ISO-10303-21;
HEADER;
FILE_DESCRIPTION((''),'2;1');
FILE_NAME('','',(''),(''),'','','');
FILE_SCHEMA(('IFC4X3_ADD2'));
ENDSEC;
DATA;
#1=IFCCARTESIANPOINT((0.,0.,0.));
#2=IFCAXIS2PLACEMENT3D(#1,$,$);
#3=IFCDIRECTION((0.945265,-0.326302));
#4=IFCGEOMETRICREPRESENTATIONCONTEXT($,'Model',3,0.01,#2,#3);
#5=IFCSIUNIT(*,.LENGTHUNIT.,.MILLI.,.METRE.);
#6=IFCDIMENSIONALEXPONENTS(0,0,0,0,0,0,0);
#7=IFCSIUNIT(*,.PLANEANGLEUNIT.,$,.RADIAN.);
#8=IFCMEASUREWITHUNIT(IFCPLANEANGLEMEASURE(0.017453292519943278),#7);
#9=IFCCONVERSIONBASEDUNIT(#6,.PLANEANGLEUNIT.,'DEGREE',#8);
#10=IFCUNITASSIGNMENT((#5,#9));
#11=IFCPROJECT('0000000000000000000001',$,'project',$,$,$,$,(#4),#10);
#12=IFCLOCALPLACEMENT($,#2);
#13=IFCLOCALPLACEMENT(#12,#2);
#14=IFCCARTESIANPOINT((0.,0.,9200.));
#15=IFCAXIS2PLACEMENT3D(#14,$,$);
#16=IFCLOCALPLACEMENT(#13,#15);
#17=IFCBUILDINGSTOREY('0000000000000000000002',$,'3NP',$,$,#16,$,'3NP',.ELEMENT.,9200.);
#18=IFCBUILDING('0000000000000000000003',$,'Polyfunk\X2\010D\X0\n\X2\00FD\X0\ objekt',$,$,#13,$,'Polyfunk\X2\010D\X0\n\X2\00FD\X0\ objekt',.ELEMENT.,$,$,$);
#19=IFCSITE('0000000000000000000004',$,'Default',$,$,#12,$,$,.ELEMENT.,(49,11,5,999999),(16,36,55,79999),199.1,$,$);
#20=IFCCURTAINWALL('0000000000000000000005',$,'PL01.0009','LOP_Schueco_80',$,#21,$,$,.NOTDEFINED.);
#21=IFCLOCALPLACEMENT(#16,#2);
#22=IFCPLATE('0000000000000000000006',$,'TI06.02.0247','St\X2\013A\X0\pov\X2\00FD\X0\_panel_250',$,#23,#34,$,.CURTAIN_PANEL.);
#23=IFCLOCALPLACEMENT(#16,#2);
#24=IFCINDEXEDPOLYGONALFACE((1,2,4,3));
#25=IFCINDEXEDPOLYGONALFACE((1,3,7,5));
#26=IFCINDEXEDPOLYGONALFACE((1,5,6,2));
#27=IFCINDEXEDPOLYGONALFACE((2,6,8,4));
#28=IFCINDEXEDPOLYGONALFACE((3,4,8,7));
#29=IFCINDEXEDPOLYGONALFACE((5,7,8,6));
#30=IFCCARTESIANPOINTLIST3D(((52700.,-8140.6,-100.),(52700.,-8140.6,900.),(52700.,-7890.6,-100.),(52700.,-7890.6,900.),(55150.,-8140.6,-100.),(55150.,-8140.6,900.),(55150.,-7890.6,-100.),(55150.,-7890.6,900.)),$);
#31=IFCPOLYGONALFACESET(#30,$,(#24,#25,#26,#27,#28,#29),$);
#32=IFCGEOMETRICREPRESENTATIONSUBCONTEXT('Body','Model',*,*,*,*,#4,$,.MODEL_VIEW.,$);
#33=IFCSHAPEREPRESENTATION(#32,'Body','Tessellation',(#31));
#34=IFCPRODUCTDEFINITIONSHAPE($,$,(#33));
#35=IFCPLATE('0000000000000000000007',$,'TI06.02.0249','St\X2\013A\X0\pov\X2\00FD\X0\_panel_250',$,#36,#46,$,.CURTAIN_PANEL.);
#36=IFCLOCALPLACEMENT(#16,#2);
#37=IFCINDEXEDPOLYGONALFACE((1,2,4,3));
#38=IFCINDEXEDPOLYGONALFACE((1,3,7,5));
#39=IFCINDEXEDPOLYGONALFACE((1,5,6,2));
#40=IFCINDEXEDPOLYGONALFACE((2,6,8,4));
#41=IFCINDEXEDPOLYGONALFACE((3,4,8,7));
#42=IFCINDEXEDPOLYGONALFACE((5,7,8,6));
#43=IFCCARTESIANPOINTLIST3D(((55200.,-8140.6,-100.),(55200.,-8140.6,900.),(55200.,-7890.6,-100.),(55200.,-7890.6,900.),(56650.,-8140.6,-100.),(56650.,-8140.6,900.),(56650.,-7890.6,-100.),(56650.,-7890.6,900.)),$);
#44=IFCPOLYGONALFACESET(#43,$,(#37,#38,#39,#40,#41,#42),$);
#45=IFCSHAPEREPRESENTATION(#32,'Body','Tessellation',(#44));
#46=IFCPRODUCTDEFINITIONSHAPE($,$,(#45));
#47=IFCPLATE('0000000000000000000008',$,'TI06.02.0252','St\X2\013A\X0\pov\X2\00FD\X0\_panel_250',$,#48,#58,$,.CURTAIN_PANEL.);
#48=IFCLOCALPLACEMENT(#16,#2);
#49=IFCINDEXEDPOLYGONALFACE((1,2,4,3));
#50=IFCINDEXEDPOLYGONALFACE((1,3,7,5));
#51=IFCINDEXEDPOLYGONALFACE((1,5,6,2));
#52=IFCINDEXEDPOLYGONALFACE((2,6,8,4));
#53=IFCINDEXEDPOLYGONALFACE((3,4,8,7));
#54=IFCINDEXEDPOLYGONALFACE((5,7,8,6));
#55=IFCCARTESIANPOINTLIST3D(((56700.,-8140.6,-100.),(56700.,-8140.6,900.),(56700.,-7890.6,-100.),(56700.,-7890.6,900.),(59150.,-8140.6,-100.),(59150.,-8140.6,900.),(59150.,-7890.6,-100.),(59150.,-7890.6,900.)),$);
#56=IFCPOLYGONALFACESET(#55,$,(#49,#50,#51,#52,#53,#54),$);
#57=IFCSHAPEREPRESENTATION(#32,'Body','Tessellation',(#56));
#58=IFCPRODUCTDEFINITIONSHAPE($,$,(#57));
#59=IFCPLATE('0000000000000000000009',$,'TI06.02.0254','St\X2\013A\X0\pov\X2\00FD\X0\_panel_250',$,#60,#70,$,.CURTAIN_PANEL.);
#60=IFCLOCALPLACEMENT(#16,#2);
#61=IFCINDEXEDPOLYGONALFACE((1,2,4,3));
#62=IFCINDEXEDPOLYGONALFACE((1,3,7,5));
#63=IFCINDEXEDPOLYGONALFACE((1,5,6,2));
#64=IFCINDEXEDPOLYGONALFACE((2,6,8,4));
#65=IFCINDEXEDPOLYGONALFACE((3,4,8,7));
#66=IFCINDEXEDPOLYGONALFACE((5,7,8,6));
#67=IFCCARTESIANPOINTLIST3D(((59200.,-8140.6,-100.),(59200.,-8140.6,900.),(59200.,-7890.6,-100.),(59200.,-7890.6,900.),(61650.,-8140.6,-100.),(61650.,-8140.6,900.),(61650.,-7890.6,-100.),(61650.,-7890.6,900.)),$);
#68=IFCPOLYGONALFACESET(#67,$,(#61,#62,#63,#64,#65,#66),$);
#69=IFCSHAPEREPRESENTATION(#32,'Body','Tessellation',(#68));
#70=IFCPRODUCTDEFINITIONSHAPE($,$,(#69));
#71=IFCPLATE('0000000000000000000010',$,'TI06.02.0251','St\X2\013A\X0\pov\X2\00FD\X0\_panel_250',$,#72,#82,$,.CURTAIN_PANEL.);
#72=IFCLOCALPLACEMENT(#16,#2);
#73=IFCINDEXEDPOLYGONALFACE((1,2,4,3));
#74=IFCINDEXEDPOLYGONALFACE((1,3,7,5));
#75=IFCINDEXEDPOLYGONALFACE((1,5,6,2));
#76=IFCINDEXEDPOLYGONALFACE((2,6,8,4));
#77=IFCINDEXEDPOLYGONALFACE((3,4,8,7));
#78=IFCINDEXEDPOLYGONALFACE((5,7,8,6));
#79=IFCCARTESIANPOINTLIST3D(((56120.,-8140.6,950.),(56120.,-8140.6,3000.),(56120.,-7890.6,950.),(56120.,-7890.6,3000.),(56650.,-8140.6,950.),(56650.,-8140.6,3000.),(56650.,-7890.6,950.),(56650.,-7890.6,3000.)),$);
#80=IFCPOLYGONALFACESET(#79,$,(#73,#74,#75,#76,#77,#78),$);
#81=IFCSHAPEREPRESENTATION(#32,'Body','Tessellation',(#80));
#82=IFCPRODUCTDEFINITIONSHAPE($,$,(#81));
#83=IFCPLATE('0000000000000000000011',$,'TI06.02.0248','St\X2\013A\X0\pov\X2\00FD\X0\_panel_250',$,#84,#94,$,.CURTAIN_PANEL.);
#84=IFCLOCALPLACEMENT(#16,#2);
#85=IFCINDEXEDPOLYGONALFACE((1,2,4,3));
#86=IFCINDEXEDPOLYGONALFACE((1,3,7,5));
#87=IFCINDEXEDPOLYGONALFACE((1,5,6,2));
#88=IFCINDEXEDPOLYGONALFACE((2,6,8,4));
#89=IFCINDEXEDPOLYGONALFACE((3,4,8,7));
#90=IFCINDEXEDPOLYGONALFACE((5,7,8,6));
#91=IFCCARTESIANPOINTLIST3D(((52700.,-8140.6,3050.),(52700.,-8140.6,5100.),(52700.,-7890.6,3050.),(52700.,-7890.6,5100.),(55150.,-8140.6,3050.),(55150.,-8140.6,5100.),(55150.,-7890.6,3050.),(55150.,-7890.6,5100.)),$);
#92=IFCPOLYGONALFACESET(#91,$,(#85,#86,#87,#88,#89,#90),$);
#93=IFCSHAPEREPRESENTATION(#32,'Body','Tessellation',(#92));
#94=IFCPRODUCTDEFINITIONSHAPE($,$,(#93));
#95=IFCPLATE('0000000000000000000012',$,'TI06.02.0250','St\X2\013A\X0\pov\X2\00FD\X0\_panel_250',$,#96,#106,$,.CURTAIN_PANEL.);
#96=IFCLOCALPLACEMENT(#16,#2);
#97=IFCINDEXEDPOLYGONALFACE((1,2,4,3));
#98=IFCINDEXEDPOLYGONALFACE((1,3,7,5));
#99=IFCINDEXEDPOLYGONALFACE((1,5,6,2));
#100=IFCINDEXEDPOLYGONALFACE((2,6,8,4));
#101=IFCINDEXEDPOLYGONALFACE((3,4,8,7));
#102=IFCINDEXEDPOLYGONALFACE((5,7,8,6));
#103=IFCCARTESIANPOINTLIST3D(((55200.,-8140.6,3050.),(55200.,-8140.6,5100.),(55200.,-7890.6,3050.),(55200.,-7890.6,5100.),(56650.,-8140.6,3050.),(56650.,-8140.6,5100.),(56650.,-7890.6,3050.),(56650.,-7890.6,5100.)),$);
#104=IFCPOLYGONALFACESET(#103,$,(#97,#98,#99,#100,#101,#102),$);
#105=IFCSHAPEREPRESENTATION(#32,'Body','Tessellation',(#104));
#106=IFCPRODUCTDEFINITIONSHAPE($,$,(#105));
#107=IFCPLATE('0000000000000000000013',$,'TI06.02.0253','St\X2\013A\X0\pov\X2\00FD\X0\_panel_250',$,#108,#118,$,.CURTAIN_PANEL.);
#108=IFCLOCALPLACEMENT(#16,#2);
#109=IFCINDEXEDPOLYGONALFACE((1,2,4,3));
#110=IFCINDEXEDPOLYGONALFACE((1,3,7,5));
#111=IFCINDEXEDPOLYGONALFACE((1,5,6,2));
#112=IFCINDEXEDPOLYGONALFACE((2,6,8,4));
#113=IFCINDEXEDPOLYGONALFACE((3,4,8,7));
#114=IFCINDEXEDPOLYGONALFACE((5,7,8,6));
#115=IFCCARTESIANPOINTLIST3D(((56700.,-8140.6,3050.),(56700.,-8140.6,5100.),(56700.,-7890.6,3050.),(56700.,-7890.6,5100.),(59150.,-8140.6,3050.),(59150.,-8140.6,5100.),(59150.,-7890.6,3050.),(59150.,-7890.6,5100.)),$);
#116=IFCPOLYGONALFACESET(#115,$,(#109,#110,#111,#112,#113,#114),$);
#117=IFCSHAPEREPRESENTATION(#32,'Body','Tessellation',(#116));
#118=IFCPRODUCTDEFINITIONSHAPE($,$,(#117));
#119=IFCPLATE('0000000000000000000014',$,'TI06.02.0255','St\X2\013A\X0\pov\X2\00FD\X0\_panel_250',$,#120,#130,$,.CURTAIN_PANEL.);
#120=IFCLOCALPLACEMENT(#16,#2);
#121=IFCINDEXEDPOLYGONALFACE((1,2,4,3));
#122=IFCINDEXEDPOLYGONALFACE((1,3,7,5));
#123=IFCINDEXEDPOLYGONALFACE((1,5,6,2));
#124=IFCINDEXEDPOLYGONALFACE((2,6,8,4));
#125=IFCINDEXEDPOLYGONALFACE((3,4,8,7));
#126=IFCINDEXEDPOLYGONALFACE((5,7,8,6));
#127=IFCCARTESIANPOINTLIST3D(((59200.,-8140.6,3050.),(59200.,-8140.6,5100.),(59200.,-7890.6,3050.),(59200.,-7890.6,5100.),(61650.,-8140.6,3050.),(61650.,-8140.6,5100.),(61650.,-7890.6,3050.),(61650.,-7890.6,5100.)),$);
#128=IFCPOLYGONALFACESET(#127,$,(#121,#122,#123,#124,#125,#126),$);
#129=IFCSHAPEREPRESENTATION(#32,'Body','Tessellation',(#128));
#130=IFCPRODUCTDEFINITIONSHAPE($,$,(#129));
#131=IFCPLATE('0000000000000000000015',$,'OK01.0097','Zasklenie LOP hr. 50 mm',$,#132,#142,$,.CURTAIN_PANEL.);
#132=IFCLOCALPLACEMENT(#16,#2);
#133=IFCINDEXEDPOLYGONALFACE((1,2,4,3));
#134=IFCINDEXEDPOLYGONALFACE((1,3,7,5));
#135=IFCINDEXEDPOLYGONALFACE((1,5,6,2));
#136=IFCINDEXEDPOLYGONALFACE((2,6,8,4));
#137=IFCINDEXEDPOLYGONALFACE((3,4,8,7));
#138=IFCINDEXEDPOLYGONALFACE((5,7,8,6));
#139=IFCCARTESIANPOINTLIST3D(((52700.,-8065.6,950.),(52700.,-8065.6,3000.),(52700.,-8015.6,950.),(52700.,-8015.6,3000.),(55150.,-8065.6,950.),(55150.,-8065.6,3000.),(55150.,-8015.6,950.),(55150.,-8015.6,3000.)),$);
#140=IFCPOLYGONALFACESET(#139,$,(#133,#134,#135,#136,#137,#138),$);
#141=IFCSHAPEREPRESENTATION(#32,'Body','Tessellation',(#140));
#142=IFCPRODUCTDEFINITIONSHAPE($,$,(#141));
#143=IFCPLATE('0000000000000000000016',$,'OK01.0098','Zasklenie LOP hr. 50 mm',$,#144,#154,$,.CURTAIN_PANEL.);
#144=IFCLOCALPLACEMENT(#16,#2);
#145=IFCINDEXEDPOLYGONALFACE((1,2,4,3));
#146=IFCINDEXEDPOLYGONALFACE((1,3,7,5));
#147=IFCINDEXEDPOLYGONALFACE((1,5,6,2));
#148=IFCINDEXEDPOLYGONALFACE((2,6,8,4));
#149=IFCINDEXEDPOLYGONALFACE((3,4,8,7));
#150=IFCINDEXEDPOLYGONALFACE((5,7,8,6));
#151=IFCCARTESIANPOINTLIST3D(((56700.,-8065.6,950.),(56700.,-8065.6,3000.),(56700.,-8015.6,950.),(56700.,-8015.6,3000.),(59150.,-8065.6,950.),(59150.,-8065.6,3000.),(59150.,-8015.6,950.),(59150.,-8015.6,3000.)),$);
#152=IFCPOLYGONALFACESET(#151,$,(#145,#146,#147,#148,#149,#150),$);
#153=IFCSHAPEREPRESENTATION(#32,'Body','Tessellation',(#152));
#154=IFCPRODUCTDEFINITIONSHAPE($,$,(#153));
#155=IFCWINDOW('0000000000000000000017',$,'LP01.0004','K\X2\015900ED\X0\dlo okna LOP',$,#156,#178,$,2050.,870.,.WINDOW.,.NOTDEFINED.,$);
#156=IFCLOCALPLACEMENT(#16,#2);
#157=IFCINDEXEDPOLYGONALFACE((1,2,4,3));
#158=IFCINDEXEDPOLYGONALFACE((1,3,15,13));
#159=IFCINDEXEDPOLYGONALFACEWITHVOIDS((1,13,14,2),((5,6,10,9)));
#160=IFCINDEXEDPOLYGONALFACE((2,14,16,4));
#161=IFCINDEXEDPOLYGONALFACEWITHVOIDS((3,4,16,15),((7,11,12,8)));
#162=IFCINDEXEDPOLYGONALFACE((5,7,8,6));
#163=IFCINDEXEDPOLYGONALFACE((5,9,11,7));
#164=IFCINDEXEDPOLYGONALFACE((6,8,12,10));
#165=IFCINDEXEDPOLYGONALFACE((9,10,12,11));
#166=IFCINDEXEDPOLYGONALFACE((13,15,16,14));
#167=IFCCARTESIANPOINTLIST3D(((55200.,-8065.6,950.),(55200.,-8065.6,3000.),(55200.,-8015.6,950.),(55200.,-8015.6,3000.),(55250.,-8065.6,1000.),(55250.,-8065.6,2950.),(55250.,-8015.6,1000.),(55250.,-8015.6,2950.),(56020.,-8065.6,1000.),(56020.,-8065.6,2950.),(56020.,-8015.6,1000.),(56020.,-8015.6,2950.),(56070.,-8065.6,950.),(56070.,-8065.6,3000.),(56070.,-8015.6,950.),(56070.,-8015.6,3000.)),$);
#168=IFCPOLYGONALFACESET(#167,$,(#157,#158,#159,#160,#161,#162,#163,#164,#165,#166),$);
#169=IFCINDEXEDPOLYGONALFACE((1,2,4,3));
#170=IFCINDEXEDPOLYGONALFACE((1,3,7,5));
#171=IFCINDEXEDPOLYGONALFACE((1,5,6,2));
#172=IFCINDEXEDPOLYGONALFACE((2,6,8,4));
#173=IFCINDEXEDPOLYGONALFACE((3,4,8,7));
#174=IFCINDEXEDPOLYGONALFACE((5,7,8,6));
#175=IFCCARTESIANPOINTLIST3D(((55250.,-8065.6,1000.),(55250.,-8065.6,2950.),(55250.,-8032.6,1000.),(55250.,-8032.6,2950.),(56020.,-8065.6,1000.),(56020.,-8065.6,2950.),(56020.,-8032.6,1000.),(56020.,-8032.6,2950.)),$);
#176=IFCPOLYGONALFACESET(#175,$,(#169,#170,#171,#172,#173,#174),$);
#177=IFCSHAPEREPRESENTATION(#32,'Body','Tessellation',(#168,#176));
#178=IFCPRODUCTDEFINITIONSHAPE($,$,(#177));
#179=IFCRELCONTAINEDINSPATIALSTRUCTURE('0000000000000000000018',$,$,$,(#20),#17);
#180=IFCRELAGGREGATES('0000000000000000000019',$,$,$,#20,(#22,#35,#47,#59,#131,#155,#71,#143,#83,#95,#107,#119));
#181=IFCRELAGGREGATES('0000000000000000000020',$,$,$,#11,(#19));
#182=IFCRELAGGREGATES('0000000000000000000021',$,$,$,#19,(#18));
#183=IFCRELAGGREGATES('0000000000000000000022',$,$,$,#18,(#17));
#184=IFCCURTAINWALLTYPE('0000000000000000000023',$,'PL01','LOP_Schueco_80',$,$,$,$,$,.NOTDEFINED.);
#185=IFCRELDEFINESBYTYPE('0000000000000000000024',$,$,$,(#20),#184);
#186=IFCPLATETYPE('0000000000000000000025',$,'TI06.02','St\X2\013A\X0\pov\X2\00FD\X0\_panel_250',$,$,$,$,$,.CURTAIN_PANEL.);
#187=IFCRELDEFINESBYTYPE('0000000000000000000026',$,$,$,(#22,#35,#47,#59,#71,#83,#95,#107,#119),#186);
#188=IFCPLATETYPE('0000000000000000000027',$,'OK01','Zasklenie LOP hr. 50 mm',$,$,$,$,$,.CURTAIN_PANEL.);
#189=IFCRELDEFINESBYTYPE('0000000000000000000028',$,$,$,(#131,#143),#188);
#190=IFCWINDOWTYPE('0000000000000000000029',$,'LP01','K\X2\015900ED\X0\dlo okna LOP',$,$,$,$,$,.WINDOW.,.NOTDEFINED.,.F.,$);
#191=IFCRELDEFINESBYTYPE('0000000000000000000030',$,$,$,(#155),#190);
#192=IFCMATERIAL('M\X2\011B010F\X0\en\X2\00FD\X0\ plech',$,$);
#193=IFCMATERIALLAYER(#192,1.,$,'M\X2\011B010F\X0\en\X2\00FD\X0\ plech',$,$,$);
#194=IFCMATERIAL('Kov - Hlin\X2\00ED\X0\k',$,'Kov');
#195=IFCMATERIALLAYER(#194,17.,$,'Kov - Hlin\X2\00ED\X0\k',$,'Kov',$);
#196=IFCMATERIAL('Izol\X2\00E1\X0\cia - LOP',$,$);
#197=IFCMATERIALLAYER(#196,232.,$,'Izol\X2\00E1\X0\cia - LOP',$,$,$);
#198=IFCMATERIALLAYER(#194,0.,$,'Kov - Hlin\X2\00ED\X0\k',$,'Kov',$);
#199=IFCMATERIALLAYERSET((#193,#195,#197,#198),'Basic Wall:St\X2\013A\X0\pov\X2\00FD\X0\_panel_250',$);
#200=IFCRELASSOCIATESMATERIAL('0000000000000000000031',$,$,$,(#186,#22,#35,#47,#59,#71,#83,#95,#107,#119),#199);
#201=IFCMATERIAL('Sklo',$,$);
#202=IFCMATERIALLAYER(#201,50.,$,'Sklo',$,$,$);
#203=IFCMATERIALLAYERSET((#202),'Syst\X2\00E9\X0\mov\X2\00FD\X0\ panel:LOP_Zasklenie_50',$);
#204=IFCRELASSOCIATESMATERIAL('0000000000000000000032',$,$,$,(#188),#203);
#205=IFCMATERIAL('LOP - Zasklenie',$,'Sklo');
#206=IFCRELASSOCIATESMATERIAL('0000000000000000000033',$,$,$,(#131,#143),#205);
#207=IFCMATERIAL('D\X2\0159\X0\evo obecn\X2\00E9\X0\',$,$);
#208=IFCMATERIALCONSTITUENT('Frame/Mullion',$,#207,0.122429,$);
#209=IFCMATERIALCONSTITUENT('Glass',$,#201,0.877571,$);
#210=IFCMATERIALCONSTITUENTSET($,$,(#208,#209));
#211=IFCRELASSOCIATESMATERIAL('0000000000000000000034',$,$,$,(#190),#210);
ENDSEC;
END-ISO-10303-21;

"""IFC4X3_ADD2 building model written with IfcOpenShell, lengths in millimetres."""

from ifc_helpers import new_model, entity, si_unit, converted_unit, direction, frame, frame_2d, origin, origin_2d_with_axis, place, context, subcontext, project, spatial, polyline, rectangle, outline, extrude, source, transform, mapped, material, layer, layer_set, layer_usage, constituent, constituent_set, type_object, type_shapes, element, aggregate, save


model = new_model("IFC4X3_ADD2")

# Units and contexts
model_context = context("Model", 3, precision=0.01, world=origin(), true_north=direction((0.945265, -0.326302)))
body_context = subcontext(model_context, "Body", "Model", "MODEL_VIEW")
ifc_project = project(units=[si_unit("LENGTHUNIT", "METRE", prefix="MILLI"), converted_unit("PLANEANGLEUNIT", "DEGREE", entity("IfcPlaneAngleMeasure", 0.017453292519943278), si_unit("PLANEANGLEUNIT", "RADIAN"), dimensions=[0, 0, 0, 0, 0, 0, 0])], contexts=[model_context])

# Site, building, storey
site_placement = place(None, origin())
site = spatial("IfcSite", under=ifc_project, at=site_placement, Name="Default", CompositionType="ELEMENT", RefLatitude=(49, 11, 5, 999999), RefLongitude=(16, 36, 55, 79999), RefElevation=199.1)
building_placement = place(site_placement, origin())
building = spatial("IfcBuilding", under=site, at=building_placement, Name="Polyfunkčný objekt", LongName="Polyfunkčný objekt", CompositionType="ELEMENT")
storey_placement = place(building_placement, frame((0.0, 0.0, 9200.0)))
storey = spatial("IfcBuildingStorey", under=building, at=storey_placement, Name="3NP", LongName="3NP", CompositionType="ELEMENT", Elevation=9200.0)

# Curtain wall, plates, window
curtain_wall_type = type_object("IfcCurtainWallType", Name="PL01", Description="LOP_Schueco_80", PredefinedType="NOTDEFINED")
curtain_wall_placement = place(storey_placement, frame((0.0, 0.0, -9200.0)))
curtain_wall = element("IfcCurtainWall", 1, at=curtain_wall_placement, inside=storey, type_object=curtain_wall_type, Name="PL01.0009", Description="LOP_Schueco_80", PredefinedType="NOTDEFINED")
ifc_material_1 = material(Name="Měďený plech")
ifc_layer_1 = layer(ifc_material_1, 1.0, Name="Měďený plech")
ifc_material_2 = material(Name="Kov - Hliník", Category="Kov")
ifc_layer_2 = layer(ifc_material_2, 17.0, Name="Kov - Hliník", Category="Kov")
ifc_material_3 = material(Name="Izolácia - LOP")
ifc_layer_3 = layer(ifc_material_3, 232.0, Name="Izolácia - LOP")
ifc_layer_4 = layer(ifc_material_2, 0.0, Name="Kov - Hliník", Category="Kov")
ifc_layer_set_1 = layer_set([ifc_layer_1, ifc_layer_2, ifc_layer_3, ifc_layer_4], Name="Basic Wall:Stĺpový_panel_250")
ifc_layer_usage_1 = layer_usage(ifc_layer_set_1, "AXIS2", "POSITIVE", -125.0)
plate_type_1 = type_object("IfcPlateType", Name="TI06.02", Description="Stĺpový_panel_250", PredefinedType="CURTAIN_PANEL", material=ifc_layer_set_1)
plate_1_placement = place(storey_placement, frame((52700.0, -8015.6, -100.0)))
plate_1 = element("IfcPlate", 2, at=plate_1_placement, type_object=plate_type_1, material=ifc_layer_usage_1, Name="TI06.02.0247", Description="Stĺpový_panel_250", PredefinedType="CURTAIN_PANEL", context=body_context, shape_type="SweptSolid", body=[
    extrude(rectangle(XDim=250.0, YDim=2450.0, at=frame_2d((0.0, 0.0), x_axis=(1.0, 0.0))), frame((1225.0, 0.0, 0.0), z_axis=(0.0, 0.0, 1.0), x_axis=(0.0, 1.0, 0.0)), (0.0, 0.0, 1.0), 1000.0),
])
ifc_layer_usage_2 = layer_usage(ifc_layer_set_1, "AXIS2", "POSITIVE", -125.0)
plate_2_placement = place(storey_placement, frame((55200.0, -8015.6, -100.0)))
plate_2 = element("IfcPlate", 3, at=plate_2_placement, type_object=plate_type_1, material=ifc_layer_usage_2, Name="TI06.02.0249", Description="Stĺpový_panel_250", PredefinedType="CURTAIN_PANEL", context=body_context, shape_type="SweptSolid", body=[
    extrude(rectangle(XDim=250.0, YDim=1450.0, at=frame_2d((0.0, 0.0), x_axis=(1.0, 0.0))), frame((725.0, 0.0, 0.0), z_axis=(0.0, 0.0, 1.0), x_axis=(0.0, 1.0, 0.0)), (0.0, 0.0, 1.0), 1000.0),
])
ifc_layer_usage_3 = layer_usage(ifc_layer_set_1, "AXIS2", "POSITIVE", -125.0)
plate_3_placement = place(storey_placement, frame((56700.0, -8015.6, -100.0)))
plate_3 = element("IfcPlate", 4, at=plate_3_placement, type_object=plate_type_1, material=ifc_layer_usage_3, Name="TI06.02.0252", Description="Stĺpový_panel_250", PredefinedType="CURTAIN_PANEL", context=body_context, shape_type="SweptSolid", body=[
    extrude(rectangle(XDim=250.0, YDim=2450.0, at=frame_2d((0.0, 0.0), x_axis=(1.0, 0.0))), frame((1225.0, 0.0, 0.0), z_axis=(0.0, 0.0, 1.0), x_axis=(0.0, 1.0, 0.0)), (0.0, 0.0, 1.0), 1000.0),
])
ifc_layer_usage_4 = layer_usage(ifc_layer_set_1, "AXIS2", "POSITIVE", -125.0)
plate_4_placement = place(storey_placement, frame((59200.0, -8015.6, -100.0)))
plate_4 = element("IfcPlate", 5, at=plate_4_placement, type_object=plate_type_1, material=ifc_layer_usage_4, Name="TI06.02.0254", Description="Stĺpový_panel_250", PredefinedType="CURTAIN_PANEL", context=body_context, shape_type="SweptSolid", body=[
    extrude(rectangle(XDim=250.0, YDim=2450.0, at=frame_2d((0.0, 0.0), x_axis=(1.0, 0.0))), frame((1225.0, 0.0, 0.0), z_axis=(0.0, 0.0, 1.0), x_axis=(0.0, 1.0, 0.0)), (0.0, 0.0, 1.0), 1000.0),
])
ifc_layer_usage_5 = layer_usage(ifc_layer_set_1, "AXIS2", "POSITIVE", -125.0)
plate_5_placement = place(storey_placement, frame((56120.0, -8015.6, 950.0)))
plate_5 = element("IfcPlate", 6, at=plate_5_placement, type_object=plate_type_1, material=ifc_layer_usage_5, Name="TI06.02.0251", Description="Stĺpový_panel_250", PredefinedType="CURTAIN_PANEL", context=body_context, shape_type="SweptSolid", body=[
    extrude(rectangle(XDim=250.0, YDim=530.0, at=origin_2d_with_axis()), frame((265.0, 0.0, 0.0), z_axis=(0.0, 0.0, 1.0), x_axis=(0.0, 1.0, 0.0)), (0.0, 0.0, 1.0), 2050.0),
])
ifc_layer_usage_6 = layer_usage(ifc_layer_set_1, "AXIS2", "POSITIVE", -125.0)
plate_6_placement = place(storey_placement, frame((52700.0, -8015.6, 3050.0)))
plate_6 = element("IfcPlate", 7, at=plate_6_placement, type_object=plate_type_1, material=ifc_layer_usage_6, Name="TI06.02.0248", Description="Stĺpový_panel_250", PredefinedType="CURTAIN_PANEL", context=body_context, shape_type="SweptSolid", body=[
    extrude(rectangle(XDim=250.0, YDim=2450.0, at=frame_2d((0.0, 0.0), x_axis=(1.0, 0.0))), frame((1225.0, 0.0, 0.0), z_axis=(0.0, 0.0, 1.0), x_axis=(0.0, 1.0, 0.0)), (0.0, 0.0, 1.0), 2050.0),
])
ifc_layer_usage_7 = layer_usage(ifc_layer_set_1, "AXIS2", "POSITIVE", -125.0)
plate_7_placement = place(storey_placement, frame((55200.0, -8015.6, 3050.0)))
plate_7 = element("IfcPlate", 8, at=plate_7_placement, type_object=plate_type_1, material=ifc_layer_usage_7, Name="TI06.02.0250", Description="Stĺpový_panel_250", PredefinedType="CURTAIN_PANEL", context=body_context, shape_type="SweptSolid", body=[
    extrude(rectangle(XDim=250.0, YDim=1450.0, at=frame_2d((0.0, 0.0), x_axis=(1.0, 0.0))), frame((725.0, 0.0, 0.0), z_axis=(0.0, 0.0, 1.0), x_axis=(0.0, 1.0, 0.0)), (0.0, 0.0, 1.0), 2050.0),
])
ifc_layer_usage_8 = layer_usage(ifc_layer_set_1, "AXIS2", "POSITIVE", -125.0)
plate_8_placement = place(storey_placement, frame((56700.0, -8015.6, 3050.0)))
plate_8 = element("IfcPlate", 9, at=plate_8_placement, type_object=plate_type_1, material=ifc_layer_usage_8, Name="TI06.02.0253", Description="Stĺpový_panel_250", PredefinedType="CURTAIN_PANEL", context=body_context, shape_type="SweptSolid", body=[
    extrude(rectangle(XDim=250.0, YDim=2450.0, at=frame_2d((0.0, 0.0), x_axis=(1.0, 0.0))), frame((1225.0, 0.0, 0.0), z_axis=(0.0, 0.0, 1.0), x_axis=(0.0, 1.0, 0.0)), (0.0, 0.0, 1.0), 2050.0),
])
ifc_layer_usage_9 = layer_usage(ifc_layer_set_1, "AXIS2", "POSITIVE", -125.0)
plate_9_placement = place(storey_placement, frame((59200.0, -8015.6, 3050.0)))
plate_9 = element("IfcPlate", 10, at=plate_9_placement, type_object=plate_type_1, material=ifc_layer_usage_9, Name="TI06.02.0255", Description="Stĺpový_panel_250", PredefinedType="CURTAIN_PANEL", context=body_context, shape_type="SweptSolid", body=[
    extrude(rectangle(XDim=250.0, YDim=2450.0, at=frame_2d((0.0, 0.0), x_axis=(1.0, 0.0))), frame((1225.0, 0.0, 0.0), z_axis=(0.0, 0.0, 1.0), x_axis=(0.0, 1.0, 0.0)), (0.0, 0.0, 1.0), 2050.0),
])
ifc_material_4 = material(Name="LOP - Zasklenie", Category="Sklo")
ifc_material_5 = material(Name="Sklo")
ifc_layer_5 = layer(ifc_material_5, 50.0, Name="Sklo")
ifc_layer_set_2 = layer_set([ifc_layer_5], Name="Systémový panel:LOP_Zasklenie_50")
plate_type_2 = type_object("IfcPlateType", Name="OK01", Description="Zasklenie LOP hr. 50 mm", PredefinedType="CURTAIN_PANEL", material=ifc_layer_set_2)
shared_shape_1 = source(origin(), body_context, "Body", "SweptSolid", [
    extrude(rectangle(XDim=50.0, YDim=2450.0, at=origin_2d_with_axis()), frame((0.0, -25.0, 0.0), z_axis=(0.0, 0.0, 1.0), x_axis=(0.0, 1.0, 0.0)), (0.0, 0.0, 1.0), 2050.0),
])
type_shapes(plate_type_2, [shared_shape_1])
plate_10_placement = place(curtain_wall_placement, frame((53925.0, -8015.6, 10150.0)))
plate_10 = element("IfcPlate", 11, at=plate_10_placement, type_object=plate_type_2, material=ifc_material_4, Name="OK01.0097", Description="Zasklenie LOP hr. 50 mm", PredefinedType="CURTAIN_PANEL", context=body_context, shape_type="MappedRepresentation", body=[
    mapped(shared_shape_1, transform((0.0, 0.0, 0.0), scale=1.0)),
])
plate_11_placement = place(curtain_wall_placement, frame((57925.0, -8015.6, 10150.0)))
plate_11 = element("IfcPlate", 12, at=plate_11_placement, type_object=plate_type_2, material=ifc_material_4, Name="OK01.0098", Description="Zasklenie LOP hr. 50 mm", PredefinedType="CURTAIN_PANEL", context=body_context, shape_type="MappedRepresentation", body=[
    mapped(shared_shape_1, transform((0.0, 0.0, 0.0), scale=1.0)),
])
ifc_material_6 = material(Name="Dřevo obecné")
ifc_constituent_1 = constituent(ifc_material_6, Name="Frame/Mullion", fraction=0.122429)
ifc_constituent_2 = constituent(ifc_material_5, Name="Glass", fraction=0.877571)
ifc_constituent_set = constituent_set(constituents=[ifc_constituent_1, ifc_constituent_2])
window_type = type_object("IfcWindowType", Name="LP01", Description="Křídlo okna LOP", ParameterTakesPrecedence=False, PartitioningType="NOTDEFINED", PredefinedType="WINDOW", material=ifc_constituent_set)
shared_shape_2 = source(origin(), body_context, "Body", "SweptSolid", [
    extrude(outline(polyline([(-1025.0, -435.0), (1025.0, -435.0), (1025.0, 435.0), (-1025.0, 435.0), (-1025.0, -435.0)]), holes=[polyline([(-975.0, -385.0), (-975.0, 385.0), (975.0, 385.0), (975.0, -385.0), (-975.0, -385.0)])]), frame((0.0, 50.0, 1025.0), z_axis=(0.0, -1.0, 0.0), x_axis=(0.0, 0.0, -1.0)), (0.0, 0.0, 1.0), 50.0),
    extrude(rectangle(XDim=770.0, YDim=33.0, at=frame_2d((0.0, 0.0), x_axis=(1.0, 0.0))), frame((0.0, 33.5, 50.0), z_axis=(0.0, 0.0, 1.0), x_axis=(-1.0, 0.0, 0.0)), (0.0, 0.0, 1.0), 1950.0),
])
type_shapes(window_type, [shared_shape_2])
window_placement = place(curtain_wall_placement, frame((55635.0, -8015.6, 10150.0), z_axis=(0.0, 0.0, 1.0), x_axis=(-1.0, 0.0, 0.0)))
window = element("IfcWindow", 13, at=window_placement, type_object=window_type, Name="LP01.0004", Description="Křídlo okna LOP", OverallHeight=2050.0, OverallWidth=870.0, PartitioningType="NOTDEFINED", PredefinedType="WINDOW", context=body_context, shape_type="MappedRepresentation", body=[
    mapped(shared_shape_2, transform((0.0, 0.0, 0.0), scale=1.0)),
])
aggregate(curtain_wall, [plate_1, plate_2, plate_3, plate_4, plate_10, window, plate_5, plate_11, plate_6, plate_7, plate_8, plate_9])

save(model, "model.ifc")
